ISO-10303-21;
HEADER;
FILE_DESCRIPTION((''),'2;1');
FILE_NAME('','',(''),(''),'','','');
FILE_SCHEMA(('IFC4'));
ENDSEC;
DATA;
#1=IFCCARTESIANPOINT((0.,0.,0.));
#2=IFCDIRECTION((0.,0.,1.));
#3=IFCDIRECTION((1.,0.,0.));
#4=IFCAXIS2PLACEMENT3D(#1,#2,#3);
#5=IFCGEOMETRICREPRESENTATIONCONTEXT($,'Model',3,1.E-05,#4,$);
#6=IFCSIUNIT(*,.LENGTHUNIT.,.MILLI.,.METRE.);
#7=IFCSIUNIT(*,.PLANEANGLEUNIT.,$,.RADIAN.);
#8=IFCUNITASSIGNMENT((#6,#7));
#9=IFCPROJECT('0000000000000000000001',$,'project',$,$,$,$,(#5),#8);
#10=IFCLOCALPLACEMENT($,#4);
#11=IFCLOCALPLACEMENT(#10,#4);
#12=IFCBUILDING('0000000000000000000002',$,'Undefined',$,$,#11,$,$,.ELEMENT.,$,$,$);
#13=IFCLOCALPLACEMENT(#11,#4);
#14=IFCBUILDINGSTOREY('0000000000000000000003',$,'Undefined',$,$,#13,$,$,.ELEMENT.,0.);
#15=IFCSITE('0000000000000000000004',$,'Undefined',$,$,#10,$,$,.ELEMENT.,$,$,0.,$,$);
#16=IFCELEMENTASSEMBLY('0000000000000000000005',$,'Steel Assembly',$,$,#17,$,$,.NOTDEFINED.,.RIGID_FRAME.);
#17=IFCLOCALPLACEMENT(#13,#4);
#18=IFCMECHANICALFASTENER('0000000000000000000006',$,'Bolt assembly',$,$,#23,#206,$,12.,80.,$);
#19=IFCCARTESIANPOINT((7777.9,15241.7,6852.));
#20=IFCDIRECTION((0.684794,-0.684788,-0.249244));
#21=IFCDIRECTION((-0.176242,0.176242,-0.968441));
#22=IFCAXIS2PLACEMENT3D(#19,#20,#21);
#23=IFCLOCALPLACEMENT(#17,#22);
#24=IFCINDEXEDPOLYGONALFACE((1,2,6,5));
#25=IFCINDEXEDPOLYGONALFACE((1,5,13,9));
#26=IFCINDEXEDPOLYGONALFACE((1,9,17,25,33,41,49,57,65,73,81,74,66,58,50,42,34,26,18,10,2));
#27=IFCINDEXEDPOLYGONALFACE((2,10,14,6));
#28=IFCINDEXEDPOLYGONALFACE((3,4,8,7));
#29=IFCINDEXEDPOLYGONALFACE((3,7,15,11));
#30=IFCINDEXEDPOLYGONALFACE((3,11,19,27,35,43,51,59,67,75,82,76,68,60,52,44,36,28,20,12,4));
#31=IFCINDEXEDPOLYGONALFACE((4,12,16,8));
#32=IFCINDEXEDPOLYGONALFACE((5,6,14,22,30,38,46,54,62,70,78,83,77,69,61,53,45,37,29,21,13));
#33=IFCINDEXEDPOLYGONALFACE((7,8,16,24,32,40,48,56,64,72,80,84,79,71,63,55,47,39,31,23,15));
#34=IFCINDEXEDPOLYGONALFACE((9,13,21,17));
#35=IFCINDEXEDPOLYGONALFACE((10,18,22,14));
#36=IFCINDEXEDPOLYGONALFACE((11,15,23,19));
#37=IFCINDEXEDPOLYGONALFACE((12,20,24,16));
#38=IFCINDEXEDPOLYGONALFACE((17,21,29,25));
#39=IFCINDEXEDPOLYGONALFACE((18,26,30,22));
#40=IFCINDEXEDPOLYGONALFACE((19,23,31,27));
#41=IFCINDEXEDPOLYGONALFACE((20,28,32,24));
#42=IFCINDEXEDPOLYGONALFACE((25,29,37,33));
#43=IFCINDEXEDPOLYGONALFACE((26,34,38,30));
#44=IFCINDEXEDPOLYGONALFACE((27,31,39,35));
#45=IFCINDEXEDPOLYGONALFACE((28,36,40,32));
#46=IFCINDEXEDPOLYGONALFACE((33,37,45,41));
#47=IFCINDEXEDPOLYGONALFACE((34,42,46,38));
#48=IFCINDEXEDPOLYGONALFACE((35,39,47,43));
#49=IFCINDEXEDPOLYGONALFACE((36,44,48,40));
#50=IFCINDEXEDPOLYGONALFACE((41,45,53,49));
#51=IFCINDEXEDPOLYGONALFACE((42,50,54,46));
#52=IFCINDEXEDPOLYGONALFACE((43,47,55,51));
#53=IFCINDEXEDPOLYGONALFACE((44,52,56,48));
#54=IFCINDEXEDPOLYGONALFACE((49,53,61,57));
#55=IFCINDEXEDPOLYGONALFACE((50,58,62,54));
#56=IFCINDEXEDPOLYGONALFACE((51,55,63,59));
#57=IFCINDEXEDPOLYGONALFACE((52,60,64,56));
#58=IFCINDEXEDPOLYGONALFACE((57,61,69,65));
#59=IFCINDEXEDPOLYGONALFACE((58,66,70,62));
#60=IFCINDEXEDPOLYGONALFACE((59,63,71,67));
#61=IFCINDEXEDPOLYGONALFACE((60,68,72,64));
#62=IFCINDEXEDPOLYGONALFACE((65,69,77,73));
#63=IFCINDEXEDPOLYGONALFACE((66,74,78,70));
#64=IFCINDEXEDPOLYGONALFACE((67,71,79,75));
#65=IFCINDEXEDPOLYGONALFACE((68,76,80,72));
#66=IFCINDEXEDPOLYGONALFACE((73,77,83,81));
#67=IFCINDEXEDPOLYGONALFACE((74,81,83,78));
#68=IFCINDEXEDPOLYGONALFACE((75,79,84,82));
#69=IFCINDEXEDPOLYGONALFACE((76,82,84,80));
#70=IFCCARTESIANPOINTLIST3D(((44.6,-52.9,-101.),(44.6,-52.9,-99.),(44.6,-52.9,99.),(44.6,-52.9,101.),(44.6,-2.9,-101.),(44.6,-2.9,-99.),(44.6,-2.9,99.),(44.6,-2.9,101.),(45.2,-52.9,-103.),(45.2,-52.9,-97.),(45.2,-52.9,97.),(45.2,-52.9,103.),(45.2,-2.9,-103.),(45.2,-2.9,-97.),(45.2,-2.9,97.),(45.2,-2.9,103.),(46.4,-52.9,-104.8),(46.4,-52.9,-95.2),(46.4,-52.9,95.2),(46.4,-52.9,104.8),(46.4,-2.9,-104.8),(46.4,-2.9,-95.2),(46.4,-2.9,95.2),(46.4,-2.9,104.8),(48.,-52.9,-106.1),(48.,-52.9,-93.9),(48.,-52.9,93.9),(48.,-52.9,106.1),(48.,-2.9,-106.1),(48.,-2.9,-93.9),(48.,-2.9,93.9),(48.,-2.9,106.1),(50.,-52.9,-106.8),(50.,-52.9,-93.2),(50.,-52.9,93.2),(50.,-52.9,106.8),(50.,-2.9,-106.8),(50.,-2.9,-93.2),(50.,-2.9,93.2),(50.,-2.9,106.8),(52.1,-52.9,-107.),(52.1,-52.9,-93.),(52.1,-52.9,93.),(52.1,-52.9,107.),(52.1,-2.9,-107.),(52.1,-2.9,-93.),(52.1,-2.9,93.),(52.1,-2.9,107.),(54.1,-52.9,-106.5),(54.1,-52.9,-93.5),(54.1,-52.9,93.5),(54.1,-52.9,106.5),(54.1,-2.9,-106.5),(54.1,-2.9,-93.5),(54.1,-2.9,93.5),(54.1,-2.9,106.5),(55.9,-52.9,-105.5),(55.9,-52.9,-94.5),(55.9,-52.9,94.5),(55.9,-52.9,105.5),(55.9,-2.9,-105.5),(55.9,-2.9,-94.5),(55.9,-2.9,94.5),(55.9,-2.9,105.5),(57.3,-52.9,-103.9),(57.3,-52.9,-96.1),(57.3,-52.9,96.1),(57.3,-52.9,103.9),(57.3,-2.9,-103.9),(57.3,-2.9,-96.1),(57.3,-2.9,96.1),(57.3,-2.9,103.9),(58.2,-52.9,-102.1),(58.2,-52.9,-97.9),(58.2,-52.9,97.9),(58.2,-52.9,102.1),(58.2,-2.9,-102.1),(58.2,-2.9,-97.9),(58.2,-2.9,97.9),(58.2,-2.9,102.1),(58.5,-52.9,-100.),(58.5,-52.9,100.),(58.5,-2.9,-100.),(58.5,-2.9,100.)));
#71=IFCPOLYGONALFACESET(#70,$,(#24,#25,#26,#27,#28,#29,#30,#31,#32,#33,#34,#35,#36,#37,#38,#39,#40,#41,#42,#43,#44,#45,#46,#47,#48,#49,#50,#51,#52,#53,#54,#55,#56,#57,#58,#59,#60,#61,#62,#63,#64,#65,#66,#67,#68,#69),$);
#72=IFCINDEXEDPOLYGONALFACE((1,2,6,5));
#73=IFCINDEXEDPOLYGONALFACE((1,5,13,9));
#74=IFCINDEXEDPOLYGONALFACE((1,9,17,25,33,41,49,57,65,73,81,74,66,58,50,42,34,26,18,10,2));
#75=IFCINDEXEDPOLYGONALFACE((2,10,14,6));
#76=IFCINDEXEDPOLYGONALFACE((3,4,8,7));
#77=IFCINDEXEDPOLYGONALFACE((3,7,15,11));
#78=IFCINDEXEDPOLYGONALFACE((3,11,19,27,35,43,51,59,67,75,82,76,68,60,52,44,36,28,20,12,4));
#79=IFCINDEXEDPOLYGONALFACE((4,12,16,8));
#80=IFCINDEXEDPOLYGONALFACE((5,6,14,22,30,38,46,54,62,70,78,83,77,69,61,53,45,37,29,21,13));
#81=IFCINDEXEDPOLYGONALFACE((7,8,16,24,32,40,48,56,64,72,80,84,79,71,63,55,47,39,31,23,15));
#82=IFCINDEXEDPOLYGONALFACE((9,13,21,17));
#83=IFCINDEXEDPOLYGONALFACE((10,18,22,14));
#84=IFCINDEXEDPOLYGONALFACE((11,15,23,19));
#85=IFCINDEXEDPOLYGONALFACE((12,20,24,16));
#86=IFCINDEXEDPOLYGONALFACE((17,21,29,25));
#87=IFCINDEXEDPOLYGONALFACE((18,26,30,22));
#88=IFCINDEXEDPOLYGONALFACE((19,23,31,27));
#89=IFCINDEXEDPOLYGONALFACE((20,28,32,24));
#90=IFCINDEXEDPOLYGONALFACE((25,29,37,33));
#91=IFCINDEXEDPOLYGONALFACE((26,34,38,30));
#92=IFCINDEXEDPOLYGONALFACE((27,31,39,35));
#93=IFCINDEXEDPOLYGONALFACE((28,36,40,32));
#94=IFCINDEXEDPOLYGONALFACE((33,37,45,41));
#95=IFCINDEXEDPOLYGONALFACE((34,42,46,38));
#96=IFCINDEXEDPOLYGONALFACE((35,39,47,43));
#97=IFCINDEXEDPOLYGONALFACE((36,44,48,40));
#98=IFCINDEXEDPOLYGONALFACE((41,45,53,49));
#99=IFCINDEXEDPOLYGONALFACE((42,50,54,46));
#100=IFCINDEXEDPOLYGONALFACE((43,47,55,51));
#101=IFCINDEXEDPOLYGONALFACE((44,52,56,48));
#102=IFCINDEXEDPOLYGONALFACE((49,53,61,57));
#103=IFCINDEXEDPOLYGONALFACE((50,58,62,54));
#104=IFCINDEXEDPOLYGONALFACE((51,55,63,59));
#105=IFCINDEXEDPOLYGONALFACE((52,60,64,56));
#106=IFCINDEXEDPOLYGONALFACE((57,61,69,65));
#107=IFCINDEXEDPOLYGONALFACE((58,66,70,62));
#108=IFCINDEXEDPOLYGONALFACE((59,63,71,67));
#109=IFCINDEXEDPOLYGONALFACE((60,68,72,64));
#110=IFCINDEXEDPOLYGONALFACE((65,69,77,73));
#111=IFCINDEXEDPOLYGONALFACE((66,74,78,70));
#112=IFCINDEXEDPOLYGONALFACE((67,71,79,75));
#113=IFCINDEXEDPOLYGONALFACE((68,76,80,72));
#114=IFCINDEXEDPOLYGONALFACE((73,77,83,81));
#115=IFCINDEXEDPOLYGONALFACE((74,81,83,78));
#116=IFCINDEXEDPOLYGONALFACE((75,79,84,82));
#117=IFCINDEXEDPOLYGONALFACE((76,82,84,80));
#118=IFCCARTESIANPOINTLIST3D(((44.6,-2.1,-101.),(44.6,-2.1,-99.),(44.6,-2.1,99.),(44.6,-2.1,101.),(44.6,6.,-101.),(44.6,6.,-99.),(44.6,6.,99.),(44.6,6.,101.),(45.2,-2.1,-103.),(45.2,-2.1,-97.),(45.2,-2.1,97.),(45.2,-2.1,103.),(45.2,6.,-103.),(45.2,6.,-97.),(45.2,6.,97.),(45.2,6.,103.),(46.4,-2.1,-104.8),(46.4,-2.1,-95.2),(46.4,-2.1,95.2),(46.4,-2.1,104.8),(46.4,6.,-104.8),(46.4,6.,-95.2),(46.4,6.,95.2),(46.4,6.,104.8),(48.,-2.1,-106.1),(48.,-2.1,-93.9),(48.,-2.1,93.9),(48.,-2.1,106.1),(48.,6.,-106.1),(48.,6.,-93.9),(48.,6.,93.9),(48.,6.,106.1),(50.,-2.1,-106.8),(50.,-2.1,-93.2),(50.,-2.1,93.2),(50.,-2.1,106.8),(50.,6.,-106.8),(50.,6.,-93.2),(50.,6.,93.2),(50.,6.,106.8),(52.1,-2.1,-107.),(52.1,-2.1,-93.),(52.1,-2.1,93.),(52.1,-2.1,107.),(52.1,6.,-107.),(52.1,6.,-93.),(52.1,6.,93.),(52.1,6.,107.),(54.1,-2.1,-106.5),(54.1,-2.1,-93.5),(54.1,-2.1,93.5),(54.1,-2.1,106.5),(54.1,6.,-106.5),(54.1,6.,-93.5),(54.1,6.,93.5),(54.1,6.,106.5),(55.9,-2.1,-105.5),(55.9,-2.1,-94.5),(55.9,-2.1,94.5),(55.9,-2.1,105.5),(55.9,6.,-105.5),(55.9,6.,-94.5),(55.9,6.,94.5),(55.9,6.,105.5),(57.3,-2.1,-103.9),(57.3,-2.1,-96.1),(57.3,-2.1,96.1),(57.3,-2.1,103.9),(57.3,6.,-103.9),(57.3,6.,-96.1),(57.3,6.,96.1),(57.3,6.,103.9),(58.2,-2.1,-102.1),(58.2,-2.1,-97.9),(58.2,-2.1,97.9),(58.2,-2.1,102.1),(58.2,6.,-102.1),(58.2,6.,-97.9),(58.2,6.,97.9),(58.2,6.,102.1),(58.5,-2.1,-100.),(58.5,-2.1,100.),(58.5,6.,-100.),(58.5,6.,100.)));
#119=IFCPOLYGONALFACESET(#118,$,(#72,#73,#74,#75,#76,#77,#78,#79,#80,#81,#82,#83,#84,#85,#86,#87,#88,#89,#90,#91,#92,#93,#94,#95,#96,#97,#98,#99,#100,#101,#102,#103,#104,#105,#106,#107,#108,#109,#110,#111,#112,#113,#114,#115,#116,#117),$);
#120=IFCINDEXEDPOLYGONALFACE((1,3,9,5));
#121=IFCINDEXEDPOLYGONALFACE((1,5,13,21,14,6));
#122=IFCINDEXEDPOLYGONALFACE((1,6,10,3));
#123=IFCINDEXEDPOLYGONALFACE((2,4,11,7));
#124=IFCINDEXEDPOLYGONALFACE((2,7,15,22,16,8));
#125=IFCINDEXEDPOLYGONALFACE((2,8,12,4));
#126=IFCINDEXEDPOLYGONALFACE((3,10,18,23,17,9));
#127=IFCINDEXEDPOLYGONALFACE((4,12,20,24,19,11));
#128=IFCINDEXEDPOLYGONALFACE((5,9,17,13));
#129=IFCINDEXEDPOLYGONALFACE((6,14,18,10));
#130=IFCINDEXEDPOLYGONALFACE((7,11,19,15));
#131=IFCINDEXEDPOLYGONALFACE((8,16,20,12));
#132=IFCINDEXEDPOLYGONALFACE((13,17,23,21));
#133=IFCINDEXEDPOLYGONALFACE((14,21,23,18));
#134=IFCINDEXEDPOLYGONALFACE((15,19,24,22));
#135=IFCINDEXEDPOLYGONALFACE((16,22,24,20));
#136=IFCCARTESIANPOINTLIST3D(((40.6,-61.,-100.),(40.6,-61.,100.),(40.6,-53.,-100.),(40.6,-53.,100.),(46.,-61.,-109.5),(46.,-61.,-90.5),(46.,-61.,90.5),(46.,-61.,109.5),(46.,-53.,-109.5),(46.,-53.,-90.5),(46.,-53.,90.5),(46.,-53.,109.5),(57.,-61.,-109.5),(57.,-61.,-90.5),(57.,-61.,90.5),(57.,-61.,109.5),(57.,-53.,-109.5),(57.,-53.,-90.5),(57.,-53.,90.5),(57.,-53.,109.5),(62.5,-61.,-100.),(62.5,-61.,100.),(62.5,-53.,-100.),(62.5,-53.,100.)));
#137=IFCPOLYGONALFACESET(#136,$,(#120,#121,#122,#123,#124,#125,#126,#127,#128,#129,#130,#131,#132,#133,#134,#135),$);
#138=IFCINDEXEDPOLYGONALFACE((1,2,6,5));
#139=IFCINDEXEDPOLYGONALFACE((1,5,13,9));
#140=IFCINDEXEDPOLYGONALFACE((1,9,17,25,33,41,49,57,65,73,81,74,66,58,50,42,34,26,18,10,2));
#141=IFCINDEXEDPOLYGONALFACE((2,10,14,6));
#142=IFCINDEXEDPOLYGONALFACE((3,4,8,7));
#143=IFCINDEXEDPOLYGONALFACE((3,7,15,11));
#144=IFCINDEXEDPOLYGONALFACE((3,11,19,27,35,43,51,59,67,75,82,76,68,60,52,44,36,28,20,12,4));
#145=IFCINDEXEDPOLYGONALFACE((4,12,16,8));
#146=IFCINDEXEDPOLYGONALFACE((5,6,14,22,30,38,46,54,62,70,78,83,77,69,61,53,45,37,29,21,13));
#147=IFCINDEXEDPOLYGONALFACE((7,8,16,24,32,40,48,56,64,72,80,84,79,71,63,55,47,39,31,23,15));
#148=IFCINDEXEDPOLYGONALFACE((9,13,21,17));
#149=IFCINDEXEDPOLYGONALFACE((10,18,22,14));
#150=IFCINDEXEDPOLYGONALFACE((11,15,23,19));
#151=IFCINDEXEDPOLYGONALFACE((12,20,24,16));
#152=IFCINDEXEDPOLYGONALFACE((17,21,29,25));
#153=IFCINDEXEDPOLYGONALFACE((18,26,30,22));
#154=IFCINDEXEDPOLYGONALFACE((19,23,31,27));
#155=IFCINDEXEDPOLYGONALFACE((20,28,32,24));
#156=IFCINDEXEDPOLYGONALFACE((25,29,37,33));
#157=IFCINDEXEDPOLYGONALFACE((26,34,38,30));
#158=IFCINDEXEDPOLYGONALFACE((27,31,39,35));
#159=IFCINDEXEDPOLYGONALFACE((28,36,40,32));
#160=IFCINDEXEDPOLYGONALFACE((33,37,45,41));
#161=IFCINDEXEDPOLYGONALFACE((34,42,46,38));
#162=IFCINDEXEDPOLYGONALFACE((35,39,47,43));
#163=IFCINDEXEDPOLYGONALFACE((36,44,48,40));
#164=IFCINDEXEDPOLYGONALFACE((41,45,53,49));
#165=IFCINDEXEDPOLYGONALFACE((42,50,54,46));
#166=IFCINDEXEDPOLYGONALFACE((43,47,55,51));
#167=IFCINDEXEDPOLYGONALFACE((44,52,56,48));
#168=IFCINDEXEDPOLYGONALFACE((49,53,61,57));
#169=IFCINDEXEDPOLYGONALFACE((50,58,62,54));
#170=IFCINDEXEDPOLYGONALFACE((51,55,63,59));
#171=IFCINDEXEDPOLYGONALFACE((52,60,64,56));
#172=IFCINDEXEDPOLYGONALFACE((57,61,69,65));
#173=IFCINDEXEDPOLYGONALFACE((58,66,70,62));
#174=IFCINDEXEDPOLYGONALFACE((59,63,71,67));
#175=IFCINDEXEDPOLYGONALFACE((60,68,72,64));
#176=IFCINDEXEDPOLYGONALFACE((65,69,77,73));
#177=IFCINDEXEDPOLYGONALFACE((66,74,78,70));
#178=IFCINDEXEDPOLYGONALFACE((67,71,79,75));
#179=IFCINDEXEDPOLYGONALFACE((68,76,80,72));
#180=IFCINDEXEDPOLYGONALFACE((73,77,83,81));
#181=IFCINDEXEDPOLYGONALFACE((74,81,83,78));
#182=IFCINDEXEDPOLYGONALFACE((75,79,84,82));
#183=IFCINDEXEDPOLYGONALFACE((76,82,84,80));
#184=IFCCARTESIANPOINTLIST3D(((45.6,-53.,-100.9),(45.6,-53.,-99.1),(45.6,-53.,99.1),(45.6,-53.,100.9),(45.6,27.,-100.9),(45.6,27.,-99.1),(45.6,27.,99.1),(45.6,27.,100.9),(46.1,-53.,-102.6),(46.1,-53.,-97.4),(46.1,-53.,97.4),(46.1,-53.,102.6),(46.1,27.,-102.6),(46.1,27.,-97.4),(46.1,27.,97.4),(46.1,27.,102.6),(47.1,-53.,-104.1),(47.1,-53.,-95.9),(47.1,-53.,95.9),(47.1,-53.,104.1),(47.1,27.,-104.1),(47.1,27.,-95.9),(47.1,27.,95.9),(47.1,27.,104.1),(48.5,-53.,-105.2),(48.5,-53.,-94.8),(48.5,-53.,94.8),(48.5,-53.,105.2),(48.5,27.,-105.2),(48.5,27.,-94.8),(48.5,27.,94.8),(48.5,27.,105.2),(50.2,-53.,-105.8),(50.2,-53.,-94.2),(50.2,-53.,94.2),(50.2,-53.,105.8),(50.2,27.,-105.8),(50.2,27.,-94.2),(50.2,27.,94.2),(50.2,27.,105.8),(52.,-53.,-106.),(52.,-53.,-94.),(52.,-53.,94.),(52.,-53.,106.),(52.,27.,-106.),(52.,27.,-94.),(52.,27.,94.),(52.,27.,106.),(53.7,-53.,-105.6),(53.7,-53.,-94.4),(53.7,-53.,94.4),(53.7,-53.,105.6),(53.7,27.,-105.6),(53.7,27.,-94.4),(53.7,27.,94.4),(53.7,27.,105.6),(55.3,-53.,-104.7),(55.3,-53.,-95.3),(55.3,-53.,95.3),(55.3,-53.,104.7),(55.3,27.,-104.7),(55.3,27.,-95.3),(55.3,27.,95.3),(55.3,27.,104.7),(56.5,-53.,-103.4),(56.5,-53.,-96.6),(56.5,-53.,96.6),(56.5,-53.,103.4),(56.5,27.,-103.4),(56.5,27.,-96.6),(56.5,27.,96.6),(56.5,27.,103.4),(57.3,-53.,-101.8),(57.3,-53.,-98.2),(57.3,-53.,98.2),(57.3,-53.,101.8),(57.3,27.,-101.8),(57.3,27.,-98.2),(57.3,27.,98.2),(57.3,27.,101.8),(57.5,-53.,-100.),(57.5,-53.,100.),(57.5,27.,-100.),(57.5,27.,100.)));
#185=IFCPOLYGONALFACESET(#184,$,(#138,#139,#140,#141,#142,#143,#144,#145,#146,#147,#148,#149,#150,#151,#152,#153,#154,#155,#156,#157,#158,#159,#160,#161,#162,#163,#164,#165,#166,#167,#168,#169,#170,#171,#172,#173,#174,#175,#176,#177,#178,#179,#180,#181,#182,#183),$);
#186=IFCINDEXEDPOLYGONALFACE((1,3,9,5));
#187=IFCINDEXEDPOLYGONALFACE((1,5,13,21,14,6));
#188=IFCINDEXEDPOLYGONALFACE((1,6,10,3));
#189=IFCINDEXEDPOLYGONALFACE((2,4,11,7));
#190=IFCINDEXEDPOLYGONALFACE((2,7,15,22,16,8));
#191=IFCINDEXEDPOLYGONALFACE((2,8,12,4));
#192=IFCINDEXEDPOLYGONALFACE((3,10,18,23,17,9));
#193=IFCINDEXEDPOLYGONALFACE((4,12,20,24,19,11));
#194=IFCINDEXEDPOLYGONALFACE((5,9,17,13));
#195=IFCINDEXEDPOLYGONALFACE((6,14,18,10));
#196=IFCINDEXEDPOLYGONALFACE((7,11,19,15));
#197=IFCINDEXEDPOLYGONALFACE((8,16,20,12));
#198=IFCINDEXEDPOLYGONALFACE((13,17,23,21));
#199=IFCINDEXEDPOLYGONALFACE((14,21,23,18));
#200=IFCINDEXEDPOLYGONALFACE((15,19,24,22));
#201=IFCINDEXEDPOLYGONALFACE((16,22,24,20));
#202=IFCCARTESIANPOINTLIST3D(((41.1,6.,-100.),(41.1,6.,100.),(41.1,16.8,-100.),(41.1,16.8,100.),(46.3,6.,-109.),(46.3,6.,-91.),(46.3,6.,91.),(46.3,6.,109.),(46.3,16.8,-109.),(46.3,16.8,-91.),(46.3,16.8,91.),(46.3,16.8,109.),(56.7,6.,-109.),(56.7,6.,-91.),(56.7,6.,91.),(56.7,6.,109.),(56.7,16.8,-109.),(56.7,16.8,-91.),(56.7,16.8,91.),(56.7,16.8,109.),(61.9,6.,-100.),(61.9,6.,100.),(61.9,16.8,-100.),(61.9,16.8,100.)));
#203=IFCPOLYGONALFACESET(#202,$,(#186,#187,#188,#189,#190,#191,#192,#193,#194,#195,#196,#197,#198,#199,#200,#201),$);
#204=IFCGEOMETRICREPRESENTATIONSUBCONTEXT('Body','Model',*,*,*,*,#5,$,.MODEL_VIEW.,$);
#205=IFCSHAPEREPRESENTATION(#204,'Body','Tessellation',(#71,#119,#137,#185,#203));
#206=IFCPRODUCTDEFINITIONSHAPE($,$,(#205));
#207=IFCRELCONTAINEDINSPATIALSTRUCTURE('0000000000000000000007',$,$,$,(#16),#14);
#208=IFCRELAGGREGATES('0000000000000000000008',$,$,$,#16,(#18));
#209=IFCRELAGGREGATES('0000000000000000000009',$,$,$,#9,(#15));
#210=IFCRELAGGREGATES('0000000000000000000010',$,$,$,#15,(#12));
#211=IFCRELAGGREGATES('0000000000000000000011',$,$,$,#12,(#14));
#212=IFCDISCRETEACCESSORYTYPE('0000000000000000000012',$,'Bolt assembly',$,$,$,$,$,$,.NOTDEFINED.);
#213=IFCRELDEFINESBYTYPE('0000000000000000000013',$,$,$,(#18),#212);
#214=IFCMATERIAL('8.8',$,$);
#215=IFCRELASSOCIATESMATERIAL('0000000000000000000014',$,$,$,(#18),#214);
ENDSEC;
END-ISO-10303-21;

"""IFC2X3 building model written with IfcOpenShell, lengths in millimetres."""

from ifc_helpers import new_model, si_unit, frame, origin_with_axes, origin_2d_with_axis, place, context, subcontext, project, spatial, polyline, circle, outline, extrude, source, transform, mapped, material, type_object, element, aggregate, save


model = new_model("IFC2X3")

# Units and contexts
model_context = context("Model", 3, precision=1e-05, world=origin_with_axes())
body_context = subcontext(model_context, "Body", "Model", "MODEL_VIEW")
ifc_project = project(units=[si_unit("LENGTHUNIT", "METRE", prefix="MILLI"), si_unit("PLANEANGLEUNIT", "RADIAN")], contexts=[model_context])

# Site, building, storey
site_placement = place(None, origin_with_axes())
site = spatial("IfcSite", under=ifc_project, at=site_placement, Name="Undefined", CompositionType="ELEMENT", RefElevation=0.0)
building_placement = place(site_placement, origin_with_axes())
building = spatial("IfcBuilding", under=site, at=building_placement, Name="Undefined", CompositionType="ELEMENT")
storey_placement = place(building_placement, origin_with_axes())
storey = spatial("IfcBuildingStorey", under=building, at=storey_placement, Name="Undefined", CompositionType="ELEMENT", Elevation=0.0)

# Element assembly
assembly_1_placement = place(storey_placement, origin_with_axes())
assembly_1 = element("IfcElementAssembly", 1, at=assembly_1_placement, inside=storey, Name="Steel Assembly", AssemblyPlace="NOTDEFINED", PredefinedType="RIGID_FRAME")

# Shared definitions
ifc_material_1 = material(Name="8.8")
discrete_accessory_type_1 = type_object("IfcDiscreteAccessoryType", Name="Bolt assembly")

# Mechanical fastener
shared_shape_1 = source(origin_with_axes(), body_context, "Body", "SweptSolid", [
    extrude(circle(Radius=7.0, at=origin_2d_with_axis()), frame((0.0, -52.9, 0.0), z_axis=(0.0, 1.0, 0.0), x_axis=(1.0, 0.0, 0.0)), (0.0, 0.0, 1.0), 50.0),
    extrude(circle(Radius=7.0, at=origin_2d_with_axis()), frame((0.0, -2.1, 0.0), z_axis=(0.0, 1.0, 0.0), x_axis=(1.0, 0.0, 0.0)), (0.0, 0.0, 1.0), 8.1),
    extrude(outline(polyline([(11.0, 0.0), (5.5, 9.5), (-5.5, 9.5), (-11.0, 0.0), (-5.5, -9.5), (5.5, -9.5), (11.0, 0.0)])), frame((0.0, -61.0, 0.0), z_axis=(0.0, 1.0, 0.0), x_axis=(1.0, 0.0, 0.0)), (0.0, 0.0, 1.0), 8.0),
    extrude(circle(Radius=6.0, at=origin_2d_with_axis()), frame((0.0, -53.0, 0.0), z_axis=(0.0, 1.0, 0.0), x_axis=(1.0, 0.0, 0.0)), (0.0, 0.0, 1.0), 80.0),
    extrude(outline(polyline([(10.4, 0.0), (5.2, 9.0), (-5.2, 9.0), (-10.4, 0.0), (-5.2, -9.0), (5.2, -9.0), (10.4, 0.0)])), frame((0.0, 6.0, 0.0), z_axis=(0.0, 1.0, 0.0), x_axis=(1.0, 0.0, 0.0)), (0.0, 0.0, 1.0), 10.8),
])
mechanical_fastener_1_placement = place(assembly_1_placement, frame((7777.9, 15241.7, 6852.0), z_axis=(0.684794, -0.684788, -0.249244), x_axis=(-0.176242, 0.176242, -0.968441)))
mechanical_fastener_1 = element("IfcMechanicalFastener", 2, at=mechanical_fastener_1_placement, type_object=discrete_accessory_type_1, material=ifc_material_1, Name="Bolt assembly", NominalDiameter=12.0, NominalLength=80.0, context=body_context, shape_type="MappedRepresentation", body=[
    mapped(shared_shape_1, transform((51.5, 0.0, -100.0))),
    mapped(shared_shape_1, transform((51.5, 0.0, 100.0))),
])
aggregate(assembly_1, [mechanical_fastener_1])

save(model, "model.ifc")
